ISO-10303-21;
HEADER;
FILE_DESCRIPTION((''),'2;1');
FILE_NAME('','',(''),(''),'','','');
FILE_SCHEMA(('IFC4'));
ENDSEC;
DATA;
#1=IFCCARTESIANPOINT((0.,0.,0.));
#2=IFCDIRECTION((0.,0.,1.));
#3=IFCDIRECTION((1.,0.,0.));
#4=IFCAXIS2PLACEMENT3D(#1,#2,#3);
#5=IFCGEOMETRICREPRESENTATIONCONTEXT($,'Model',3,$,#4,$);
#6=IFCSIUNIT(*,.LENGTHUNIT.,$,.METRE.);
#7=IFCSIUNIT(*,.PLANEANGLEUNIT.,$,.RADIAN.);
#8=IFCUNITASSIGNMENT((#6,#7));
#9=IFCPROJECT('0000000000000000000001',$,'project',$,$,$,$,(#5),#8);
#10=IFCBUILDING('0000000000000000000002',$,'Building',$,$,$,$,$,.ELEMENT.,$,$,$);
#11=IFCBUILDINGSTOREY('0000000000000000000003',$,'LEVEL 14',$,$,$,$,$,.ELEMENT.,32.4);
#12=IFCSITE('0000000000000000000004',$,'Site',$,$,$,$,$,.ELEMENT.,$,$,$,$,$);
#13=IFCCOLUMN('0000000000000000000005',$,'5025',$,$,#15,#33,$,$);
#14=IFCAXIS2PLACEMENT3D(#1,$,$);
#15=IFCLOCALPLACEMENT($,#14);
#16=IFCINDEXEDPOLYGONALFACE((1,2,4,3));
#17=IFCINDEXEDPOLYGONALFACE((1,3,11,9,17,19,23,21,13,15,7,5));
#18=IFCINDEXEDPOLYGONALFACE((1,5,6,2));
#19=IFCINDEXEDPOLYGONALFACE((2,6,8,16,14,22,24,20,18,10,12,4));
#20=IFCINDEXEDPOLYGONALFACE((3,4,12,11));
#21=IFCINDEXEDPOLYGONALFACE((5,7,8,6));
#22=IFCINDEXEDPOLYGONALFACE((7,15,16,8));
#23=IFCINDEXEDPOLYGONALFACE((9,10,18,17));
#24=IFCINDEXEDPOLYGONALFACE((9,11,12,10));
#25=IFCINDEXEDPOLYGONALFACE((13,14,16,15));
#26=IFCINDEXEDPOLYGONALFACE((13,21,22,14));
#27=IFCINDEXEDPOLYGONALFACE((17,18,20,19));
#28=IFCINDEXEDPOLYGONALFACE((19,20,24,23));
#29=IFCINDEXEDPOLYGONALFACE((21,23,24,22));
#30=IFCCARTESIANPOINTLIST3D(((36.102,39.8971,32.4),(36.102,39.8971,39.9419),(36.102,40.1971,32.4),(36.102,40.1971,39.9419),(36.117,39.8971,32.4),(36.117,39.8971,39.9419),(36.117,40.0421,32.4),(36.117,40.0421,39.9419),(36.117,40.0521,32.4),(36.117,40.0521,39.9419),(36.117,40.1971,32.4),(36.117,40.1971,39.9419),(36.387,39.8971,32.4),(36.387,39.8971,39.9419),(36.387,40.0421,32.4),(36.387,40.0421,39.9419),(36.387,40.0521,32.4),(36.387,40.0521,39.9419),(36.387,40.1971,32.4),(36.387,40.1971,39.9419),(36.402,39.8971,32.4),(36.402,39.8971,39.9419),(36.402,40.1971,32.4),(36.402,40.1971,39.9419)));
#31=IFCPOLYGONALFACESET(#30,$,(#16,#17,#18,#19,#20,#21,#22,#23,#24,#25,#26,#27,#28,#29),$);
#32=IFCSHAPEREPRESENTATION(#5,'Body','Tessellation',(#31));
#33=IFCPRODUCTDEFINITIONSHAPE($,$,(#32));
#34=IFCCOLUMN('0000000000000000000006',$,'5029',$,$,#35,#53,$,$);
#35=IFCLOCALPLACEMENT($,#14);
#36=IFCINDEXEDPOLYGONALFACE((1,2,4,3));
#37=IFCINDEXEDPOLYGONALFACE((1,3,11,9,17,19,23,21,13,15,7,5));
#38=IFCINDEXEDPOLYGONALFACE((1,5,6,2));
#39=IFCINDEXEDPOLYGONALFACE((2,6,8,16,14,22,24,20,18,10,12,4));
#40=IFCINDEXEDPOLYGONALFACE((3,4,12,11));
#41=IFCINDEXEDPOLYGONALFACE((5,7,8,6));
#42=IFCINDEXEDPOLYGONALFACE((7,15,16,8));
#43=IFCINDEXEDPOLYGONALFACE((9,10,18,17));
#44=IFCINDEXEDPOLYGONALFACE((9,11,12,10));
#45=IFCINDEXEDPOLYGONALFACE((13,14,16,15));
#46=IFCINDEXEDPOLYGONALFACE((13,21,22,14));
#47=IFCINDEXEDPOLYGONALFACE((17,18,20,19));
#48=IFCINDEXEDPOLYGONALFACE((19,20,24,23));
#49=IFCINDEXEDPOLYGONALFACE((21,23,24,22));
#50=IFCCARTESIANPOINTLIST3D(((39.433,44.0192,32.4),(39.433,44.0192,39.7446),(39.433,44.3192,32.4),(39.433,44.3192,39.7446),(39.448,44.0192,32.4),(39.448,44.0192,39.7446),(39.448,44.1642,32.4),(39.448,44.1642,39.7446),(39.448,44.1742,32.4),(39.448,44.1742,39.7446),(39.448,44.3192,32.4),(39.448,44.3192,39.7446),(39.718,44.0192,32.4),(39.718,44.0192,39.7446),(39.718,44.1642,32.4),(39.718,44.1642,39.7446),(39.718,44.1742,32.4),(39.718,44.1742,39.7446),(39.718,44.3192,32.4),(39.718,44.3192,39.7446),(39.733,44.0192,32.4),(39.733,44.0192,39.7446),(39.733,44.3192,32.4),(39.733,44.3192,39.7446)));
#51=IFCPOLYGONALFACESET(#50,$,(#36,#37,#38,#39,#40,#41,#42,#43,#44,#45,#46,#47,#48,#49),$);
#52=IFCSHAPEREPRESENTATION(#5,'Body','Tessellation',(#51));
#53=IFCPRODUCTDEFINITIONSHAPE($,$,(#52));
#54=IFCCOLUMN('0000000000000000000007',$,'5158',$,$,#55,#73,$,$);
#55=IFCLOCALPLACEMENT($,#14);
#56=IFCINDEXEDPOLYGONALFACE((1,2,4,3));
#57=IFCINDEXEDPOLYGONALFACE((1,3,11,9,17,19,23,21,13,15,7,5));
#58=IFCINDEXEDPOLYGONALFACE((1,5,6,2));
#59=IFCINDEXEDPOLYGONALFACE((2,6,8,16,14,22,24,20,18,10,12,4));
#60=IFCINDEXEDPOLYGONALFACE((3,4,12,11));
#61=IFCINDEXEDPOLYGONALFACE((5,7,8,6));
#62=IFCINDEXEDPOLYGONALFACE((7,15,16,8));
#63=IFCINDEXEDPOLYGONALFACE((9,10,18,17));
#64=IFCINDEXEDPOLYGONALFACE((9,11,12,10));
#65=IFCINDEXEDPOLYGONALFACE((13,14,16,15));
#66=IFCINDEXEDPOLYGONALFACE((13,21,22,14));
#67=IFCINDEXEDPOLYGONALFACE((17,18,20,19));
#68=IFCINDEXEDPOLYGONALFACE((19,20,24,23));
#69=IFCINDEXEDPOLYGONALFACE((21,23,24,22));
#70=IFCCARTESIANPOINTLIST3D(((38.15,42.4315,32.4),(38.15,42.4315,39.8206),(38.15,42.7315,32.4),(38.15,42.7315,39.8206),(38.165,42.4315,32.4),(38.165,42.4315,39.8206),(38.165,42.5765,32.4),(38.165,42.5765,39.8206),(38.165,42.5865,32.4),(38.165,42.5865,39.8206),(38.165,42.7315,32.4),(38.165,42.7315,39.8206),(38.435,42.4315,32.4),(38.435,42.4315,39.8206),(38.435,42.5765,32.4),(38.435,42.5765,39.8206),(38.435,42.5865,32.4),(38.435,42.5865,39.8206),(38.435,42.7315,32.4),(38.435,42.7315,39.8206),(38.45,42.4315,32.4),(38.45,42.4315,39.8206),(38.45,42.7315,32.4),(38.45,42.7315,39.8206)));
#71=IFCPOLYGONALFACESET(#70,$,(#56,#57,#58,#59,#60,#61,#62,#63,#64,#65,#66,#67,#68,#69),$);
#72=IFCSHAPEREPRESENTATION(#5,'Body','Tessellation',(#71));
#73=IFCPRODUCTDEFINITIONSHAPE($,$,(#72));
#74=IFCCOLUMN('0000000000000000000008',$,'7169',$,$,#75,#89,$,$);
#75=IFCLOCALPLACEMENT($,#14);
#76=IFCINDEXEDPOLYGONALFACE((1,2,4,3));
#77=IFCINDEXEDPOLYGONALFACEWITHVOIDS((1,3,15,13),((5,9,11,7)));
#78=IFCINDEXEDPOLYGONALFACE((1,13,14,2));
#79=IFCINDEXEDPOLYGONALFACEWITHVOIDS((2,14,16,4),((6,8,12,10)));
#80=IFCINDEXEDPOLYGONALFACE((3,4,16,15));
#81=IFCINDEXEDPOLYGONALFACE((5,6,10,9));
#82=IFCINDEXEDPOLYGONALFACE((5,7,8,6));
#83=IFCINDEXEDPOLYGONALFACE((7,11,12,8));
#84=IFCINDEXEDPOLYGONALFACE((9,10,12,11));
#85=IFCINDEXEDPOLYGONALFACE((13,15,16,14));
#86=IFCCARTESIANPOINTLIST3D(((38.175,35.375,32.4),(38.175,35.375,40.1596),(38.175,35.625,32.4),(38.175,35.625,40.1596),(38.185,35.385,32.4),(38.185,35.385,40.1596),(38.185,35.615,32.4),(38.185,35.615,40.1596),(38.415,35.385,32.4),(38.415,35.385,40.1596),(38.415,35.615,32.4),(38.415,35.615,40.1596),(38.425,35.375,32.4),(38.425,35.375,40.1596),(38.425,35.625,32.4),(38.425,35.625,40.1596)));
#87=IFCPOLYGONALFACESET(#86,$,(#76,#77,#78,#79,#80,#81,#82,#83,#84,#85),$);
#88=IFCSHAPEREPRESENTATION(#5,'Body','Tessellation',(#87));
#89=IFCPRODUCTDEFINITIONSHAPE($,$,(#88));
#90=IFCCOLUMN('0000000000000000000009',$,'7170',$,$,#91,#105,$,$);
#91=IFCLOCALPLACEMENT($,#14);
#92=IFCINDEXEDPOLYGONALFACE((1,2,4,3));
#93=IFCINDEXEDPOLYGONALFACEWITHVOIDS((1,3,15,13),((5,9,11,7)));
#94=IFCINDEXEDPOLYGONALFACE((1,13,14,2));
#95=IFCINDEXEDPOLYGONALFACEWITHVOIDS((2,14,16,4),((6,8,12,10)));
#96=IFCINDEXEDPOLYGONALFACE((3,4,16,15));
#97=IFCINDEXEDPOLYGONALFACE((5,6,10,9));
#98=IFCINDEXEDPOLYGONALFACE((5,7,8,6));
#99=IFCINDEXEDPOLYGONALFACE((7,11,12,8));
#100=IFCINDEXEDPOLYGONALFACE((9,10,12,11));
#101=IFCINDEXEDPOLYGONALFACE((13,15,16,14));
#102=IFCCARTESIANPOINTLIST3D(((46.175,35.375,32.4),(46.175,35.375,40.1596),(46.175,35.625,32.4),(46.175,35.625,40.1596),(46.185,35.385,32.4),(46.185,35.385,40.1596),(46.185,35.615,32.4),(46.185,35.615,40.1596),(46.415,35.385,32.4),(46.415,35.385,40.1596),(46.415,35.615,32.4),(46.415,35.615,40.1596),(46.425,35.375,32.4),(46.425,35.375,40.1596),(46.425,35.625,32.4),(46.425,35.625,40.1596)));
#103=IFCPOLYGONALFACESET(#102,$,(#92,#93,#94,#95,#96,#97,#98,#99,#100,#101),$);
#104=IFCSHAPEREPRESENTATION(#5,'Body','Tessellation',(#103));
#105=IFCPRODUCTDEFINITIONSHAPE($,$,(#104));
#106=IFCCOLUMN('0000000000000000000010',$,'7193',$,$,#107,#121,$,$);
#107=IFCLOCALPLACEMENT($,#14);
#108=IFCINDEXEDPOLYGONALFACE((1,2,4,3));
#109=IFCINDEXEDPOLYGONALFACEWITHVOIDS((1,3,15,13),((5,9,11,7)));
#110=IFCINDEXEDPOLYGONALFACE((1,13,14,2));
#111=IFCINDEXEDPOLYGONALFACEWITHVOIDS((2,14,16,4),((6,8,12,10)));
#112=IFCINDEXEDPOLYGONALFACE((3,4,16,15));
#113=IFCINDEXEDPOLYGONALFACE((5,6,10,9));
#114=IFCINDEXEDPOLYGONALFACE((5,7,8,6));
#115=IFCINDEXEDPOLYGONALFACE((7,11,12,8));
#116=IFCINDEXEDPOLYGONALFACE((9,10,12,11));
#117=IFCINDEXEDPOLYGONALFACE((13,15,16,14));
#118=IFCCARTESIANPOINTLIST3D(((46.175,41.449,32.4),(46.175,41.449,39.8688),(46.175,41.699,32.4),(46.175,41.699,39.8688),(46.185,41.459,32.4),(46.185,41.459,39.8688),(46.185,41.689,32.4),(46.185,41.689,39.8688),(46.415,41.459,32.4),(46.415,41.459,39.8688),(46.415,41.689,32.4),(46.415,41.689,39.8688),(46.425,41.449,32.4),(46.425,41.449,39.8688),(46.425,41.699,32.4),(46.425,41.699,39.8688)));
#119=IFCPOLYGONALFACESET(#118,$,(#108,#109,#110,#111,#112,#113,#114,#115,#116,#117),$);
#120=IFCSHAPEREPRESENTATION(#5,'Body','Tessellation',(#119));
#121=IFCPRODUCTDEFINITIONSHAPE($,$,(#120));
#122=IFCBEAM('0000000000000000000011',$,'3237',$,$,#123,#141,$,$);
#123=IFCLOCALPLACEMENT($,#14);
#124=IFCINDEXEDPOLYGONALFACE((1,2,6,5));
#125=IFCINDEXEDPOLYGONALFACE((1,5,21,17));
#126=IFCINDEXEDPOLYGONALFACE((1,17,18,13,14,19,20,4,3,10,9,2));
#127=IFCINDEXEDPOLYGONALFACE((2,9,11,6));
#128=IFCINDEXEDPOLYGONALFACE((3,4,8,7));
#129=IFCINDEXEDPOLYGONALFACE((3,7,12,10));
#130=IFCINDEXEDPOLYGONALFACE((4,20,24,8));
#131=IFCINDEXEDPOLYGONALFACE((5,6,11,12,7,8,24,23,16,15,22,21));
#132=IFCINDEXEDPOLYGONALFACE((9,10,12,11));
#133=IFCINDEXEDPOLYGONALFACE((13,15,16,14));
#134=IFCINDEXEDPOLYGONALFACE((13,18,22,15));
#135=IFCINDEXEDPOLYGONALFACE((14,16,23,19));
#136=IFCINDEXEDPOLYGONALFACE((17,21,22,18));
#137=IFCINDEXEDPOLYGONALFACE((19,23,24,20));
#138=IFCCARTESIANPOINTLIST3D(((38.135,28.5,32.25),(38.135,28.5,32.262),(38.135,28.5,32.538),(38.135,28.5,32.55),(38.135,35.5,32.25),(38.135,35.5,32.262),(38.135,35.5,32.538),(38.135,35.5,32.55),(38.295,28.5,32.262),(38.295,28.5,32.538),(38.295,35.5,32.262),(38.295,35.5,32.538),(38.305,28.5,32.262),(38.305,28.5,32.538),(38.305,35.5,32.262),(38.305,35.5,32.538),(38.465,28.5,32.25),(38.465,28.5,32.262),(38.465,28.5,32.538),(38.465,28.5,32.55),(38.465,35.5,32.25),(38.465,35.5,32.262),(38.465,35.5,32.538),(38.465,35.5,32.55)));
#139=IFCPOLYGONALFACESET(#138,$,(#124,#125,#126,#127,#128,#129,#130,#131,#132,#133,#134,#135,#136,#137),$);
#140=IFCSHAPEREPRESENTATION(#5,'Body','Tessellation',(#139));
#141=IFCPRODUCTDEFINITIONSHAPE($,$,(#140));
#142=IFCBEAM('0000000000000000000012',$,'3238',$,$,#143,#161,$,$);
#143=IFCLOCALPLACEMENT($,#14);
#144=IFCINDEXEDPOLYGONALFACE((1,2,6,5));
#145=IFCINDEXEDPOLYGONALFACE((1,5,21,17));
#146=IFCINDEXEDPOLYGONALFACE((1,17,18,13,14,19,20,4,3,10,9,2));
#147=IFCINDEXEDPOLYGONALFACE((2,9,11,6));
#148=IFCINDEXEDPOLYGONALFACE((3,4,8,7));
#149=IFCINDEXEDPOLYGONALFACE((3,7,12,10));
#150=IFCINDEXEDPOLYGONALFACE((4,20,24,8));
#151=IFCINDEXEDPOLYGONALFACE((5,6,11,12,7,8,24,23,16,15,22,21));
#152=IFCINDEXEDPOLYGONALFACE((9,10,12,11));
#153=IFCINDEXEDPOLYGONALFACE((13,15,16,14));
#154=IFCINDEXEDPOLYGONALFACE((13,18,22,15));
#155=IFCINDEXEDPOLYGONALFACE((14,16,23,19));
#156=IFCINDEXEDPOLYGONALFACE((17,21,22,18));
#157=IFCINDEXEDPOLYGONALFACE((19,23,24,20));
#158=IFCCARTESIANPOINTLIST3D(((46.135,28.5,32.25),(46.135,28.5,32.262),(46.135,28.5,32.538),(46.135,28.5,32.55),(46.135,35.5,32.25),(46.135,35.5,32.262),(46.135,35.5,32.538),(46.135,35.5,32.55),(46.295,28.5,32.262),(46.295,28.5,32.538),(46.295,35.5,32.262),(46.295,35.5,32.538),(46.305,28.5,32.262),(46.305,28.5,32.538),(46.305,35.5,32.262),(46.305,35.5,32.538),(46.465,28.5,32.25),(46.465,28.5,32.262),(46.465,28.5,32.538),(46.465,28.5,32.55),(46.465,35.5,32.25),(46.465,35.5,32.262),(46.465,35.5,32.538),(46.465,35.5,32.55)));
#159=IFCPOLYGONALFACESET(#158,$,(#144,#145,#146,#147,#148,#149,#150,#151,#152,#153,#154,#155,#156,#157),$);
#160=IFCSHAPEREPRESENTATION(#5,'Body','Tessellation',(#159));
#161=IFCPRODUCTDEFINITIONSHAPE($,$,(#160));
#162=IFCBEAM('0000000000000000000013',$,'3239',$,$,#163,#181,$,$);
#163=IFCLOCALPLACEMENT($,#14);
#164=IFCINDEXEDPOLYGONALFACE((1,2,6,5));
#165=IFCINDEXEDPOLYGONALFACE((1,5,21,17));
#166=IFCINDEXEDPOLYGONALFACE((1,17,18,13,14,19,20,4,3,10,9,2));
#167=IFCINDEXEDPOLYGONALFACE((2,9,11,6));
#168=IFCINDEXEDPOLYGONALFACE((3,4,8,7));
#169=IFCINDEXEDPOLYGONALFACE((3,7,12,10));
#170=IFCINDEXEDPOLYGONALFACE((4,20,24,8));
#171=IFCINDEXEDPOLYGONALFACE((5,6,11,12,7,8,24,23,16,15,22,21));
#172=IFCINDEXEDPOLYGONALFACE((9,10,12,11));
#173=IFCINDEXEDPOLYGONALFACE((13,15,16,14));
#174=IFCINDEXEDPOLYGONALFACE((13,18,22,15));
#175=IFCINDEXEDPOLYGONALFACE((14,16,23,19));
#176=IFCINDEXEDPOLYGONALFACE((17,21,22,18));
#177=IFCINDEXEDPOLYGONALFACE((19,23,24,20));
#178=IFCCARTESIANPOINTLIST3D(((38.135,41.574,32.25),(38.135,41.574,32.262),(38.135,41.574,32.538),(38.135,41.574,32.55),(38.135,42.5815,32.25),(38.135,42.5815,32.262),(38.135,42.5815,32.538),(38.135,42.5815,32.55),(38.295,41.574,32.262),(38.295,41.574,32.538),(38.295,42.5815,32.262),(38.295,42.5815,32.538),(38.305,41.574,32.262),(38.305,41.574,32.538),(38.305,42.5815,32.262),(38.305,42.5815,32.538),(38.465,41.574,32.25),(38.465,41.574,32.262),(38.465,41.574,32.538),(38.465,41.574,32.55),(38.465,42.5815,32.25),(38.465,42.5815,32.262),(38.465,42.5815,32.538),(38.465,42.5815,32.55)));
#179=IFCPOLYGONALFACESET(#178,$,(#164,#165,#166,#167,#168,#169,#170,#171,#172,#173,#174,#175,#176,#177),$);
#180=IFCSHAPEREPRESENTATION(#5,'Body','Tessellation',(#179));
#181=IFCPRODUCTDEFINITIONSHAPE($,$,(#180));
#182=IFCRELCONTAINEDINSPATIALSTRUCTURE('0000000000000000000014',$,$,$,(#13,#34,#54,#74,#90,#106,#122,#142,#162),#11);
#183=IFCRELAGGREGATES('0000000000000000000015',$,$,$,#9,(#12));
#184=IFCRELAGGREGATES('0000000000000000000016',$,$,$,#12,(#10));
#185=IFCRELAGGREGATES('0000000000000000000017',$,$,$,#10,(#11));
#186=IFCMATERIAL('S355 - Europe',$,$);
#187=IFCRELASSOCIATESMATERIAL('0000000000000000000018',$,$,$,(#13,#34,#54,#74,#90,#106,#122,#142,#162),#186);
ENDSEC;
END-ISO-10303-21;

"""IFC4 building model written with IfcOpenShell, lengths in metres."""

from ifc_helpers import new_model, si_unit, frame, origin_with_axes, origin_2d_with_axis, place, context, project, spatial, hollow_rectangle, i_section, extrude, material, material_profile, profile_set, profile_usage, element, save


model = new_model("IFC4")

# Units and contexts
model_context = context("Model", 3, world=origin_with_axes())
ifc_project = project(units=[si_unit("LENGTHUNIT", "METRE"), si_unit("PLANEANGLEUNIT", "RADIAN")], contexts=[model_context])

# Site, building, storey
site = spatial("IfcSite", under=ifc_project, Name="Site", CompositionType="ELEMENT")
building = spatial("IfcBuilding", under=site, Name="Building", CompositionType="ELEMENT")
storey = spatial("IfcBuildingStorey", under=building, Name="LEVEL 14", CompositionType="ELEMENT", Elevation=32.4)

# Columns
ifc_material = material(Name="S355 - Europe")
ifc_material_profile_1 = material_profile(ifc_material, i_section(OverallWidth=0.3, OverallDepth=0.3, WebThickness=0.01, FlangeThickness=0.015, at=origin_2d_with_axis()))
ifc_profile_set_1 = profile_set([ifc_material_profile_1])
ifc_profile_usage_1 = profile_usage(ifc_profile_set_1, cardinal=10)
column_1_placement = place(None, frame((36.252, 40.0471, 32.4), z_axis=(0.0, 0.0, 1.0), x_axis=(0.0, -1.0, 0.0)))
element("IfcColumn", 1, at=column_1_placement, inside=storey, material=ifc_profile_usage_1, Name="5025", context=model_context, shape_type="SweptSolid", body=[
    extrude(i_section(OverallWidth=0.3, OverallDepth=0.3, WebThickness=0.01, FlangeThickness=0.015, at=origin_2d_with_axis()), origin_with_axes(), (0.0, 0.0, 1.0), 7.5419),
])
ifc_material_profile_2 = material_profile(ifc_material, i_section(OverallWidth=0.3, OverallDepth=0.3, WebThickness=0.01, FlangeThickness=0.015, at=origin_2d_with_axis()))
ifc_profile_set_2 = profile_set([ifc_material_profile_2])
ifc_profile_usage_2 = profile_usage(ifc_profile_set_2, cardinal=10)
column_2_placement = place(None, frame((39.583, 44.1692, 32.4), z_axis=(0.0, 0.0, 1.0), x_axis=(0.0, -1.0, 0.0)))
element("IfcColumn", 2, at=column_2_placement, inside=storey, material=ifc_profile_usage_2, Name="5029", context=model_context, shape_type="SweptSolid", body=[
    extrude(i_section(OverallWidth=0.3, OverallDepth=0.3, WebThickness=0.01, FlangeThickness=0.015, at=origin_2d_with_axis()), origin_with_axes(), (0.0, 0.0, 1.0), 7.3446),
])
ifc_material_profile_3 = material_profile(ifc_material, i_section(OverallWidth=0.3, OverallDepth=0.3, WebThickness=0.01, FlangeThickness=0.015, at=origin_2d_with_axis()))
ifc_profile_set_3 = profile_set([ifc_material_profile_3])
ifc_profile_usage_3 = profile_usage(ifc_profile_set_3, cardinal=10)
column_3_placement = place(None, frame((38.3, 42.5815, 32.4), z_axis=(0.0, 0.0, 1.0), x_axis=(0.0, -1.0, 0.0)))
element("IfcColumn", 3, at=column_3_placement, inside=storey, material=ifc_profile_usage_3, Name="5158", context=model_context, shape_type="SweptSolid", body=[
    extrude(i_section(OverallWidth=0.3, OverallDepth=0.3, WebThickness=0.01, FlangeThickness=0.015, at=origin_2d_with_axis()), origin_with_axes(), (0.0, 0.0, 1.0), 7.4206),
])
ifc_material_profile_4 = material_profile(ifc_material, hollow_rectangle(XDim=0.25, YDim=0.25, WallThickness=0.01, at=origin_2d_with_axis()))
ifc_profile_set_4 = profile_set([ifc_material_profile_4])
ifc_profile_usage_4 = profile_usage(ifc_profile_set_4, cardinal=10)
column_4_placement = place(None, frame((38.3, 35.5, 32.4), z_axis=(0.0, 0.0, 1.0), x_axis=(0.0, -1.0, 0.0)))
element("IfcColumn", 4, at=column_4_placement, inside=storey, material=ifc_profile_usage_4, Name="7169", context=model_context, shape_type="SweptSolid", body=[
    extrude(hollow_rectangle(XDim=0.25, YDim=0.25, WallThickness=0.01, at=origin_2d_with_axis()), origin_with_axes(), (0.0, 0.0, 1.0), 7.7596),
])
ifc_material_profile_5 = material_profile(ifc_material, hollow_rectangle(XDim=0.25, YDim=0.25, WallThickness=0.01, at=origin_2d_with_axis()))
ifc_profile_set_5 = profile_set([ifc_material_profile_5])
ifc_profile_usage_5 = profile_usage(ifc_profile_set_5, cardinal=10)
column_5_placement = place(None, frame((46.3, 35.5, 32.4), z_axis=(0.0, 0.0, 1.0), x_axis=(0.0, -1.0, 0.0)))
element("IfcColumn", 5, at=column_5_placement, inside=storey, material=ifc_profile_usage_5, Name="7170", context=model_context, shape_type="SweptSolid", body=[
    extrude(hollow_rectangle(XDim=0.25, YDim=0.25, WallThickness=0.01, at=origin_2d_with_axis()), origin_with_axes(), (0.0, 0.0, 1.0), 7.7596),
])
ifc_material_profile_6 = material_profile(ifc_material, hollow_rectangle(XDim=0.25, YDim=0.25, WallThickness=0.01, at=origin_2d_with_axis()))
ifc_profile_set_6 = profile_set([ifc_material_profile_6])
ifc_profile_usage_6 = profile_usage(ifc_profile_set_6, cardinal=10)
column_6_placement = place(None, frame((46.3, 41.574, 32.4), z_axis=(0.0, 0.0, 1.0), x_axis=(0.0, -1.0, 0.0)))
element("IfcColumn", 6, at=column_6_placement, inside=storey, material=ifc_profile_usage_6, Name="7193", context=model_context, shape_type="SweptSolid", body=[
    extrude(hollow_rectangle(XDim=0.25, YDim=0.25, WallThickness=0.01, at=origin_2d_with_axis()), origin_with_axes(), (0.0, 0.0, 1.0), 7.4688),
])

# Beams
ifc_material_profile_7 = material_profile(ifc_material, i_section(OverallWidth=0.33, OverallDepth=0.3, WebThickness=0.01, FlangeThickness=0.012, at=origin_2d_with_axis()))
ifc_profile_set_7 = profile_set([ifc_material_profile_7])
ifc_profile_usage_7 = profile_usage(ifc_profile_set_7, cardinal=10)
beam_1_placement = place(None, frame((38.3, 35.5, 32.4), z_axis=(0.0, -1.0, 0.0), x_axis=(1.0, 0.0, 0.0)))
element("IfcBeam", 7, at=beam_1_placement, inside=storey, material=ifc_profile_usage_7, Name="3237", context=model_context, shape_type="SweptSolid", body=[
    extrude(i_section(OverallWidth=0.33, OverallDepth=0.3, WebThickness=0.01, FlangeThickness=0.012, at=origin_2d_with_axis()), origin_with_axes(), (0.0, 0.0, 1.0), 7.0),
])
ifc_material_profile_8 = material_profile(ifc_material, i_section(OverallWidth=0.33, OverallDepth=0.3, WebThickness=0.01, FlangeThickness=0.012, at=origin_2d_with_axis()))
ifc_profile_set_8 = profile_set([ifc_material_profile_8])
ifc_profile_usage_8 = profile_usage(ifc_profile_set_8, cardinal=10)
beam_2_placement = place(None, frame((46.3, 35.5, 32.4), z_axis=(0.0, -1.0, 0.0), x_axis=(1.0, 0.0, 0.0)))
element("IfcBeam", 8, at=beam_2_placement, inside=storey, material=ifc_profile_usage_8, Name="3238", context=model_context, shape_type="SweptSolid", body=[
    extrude(i_section(OverallWidth=0.33, OverallDepth=0.3, WebThickness=0.01, FlangeThickness=0.012, at=origin_2d_with_axis()), origin_with_axes(), (0.0, 0.0, 1.0), 7.0),
])
ifc_material_profile_9 = material_profile(ifc_material, i_section(OverallWidth=0.33, OverallDepth=0.3, WebThickness=0.01, FlangeThickness=0.012, at=origin_2d_with_axis()))
ifc_profile_set_9 = profile_set([ifc_material_profile_9])
ifc_profile_usage_9 = profile_usage(ifc_profile_set_9, cardinal=10)
beam_3_placement = place(None, frame((38.3, 42.5815, 32.4), z_axis=(0.0, -1.0, 0.0), x_axis=(1.0, 0.0, 0.0)))
element("IfcBeam", 9, at=beam_3_placement, inside=storey, material=ifc_profile_usage_9, Name="3239", context=model_context, shape_type="SweptSolid", body=[
    extrude(i_section(OverallWidth=0.33, OverallDepth=0.3, WebThickness=0.01, FlangeThickness=0.012, at=origin_2d_with_axis()), origin_with_axes(), (0.0, 0.0, 1.0), 1.0075),
])

save(model, "model.ifc")
